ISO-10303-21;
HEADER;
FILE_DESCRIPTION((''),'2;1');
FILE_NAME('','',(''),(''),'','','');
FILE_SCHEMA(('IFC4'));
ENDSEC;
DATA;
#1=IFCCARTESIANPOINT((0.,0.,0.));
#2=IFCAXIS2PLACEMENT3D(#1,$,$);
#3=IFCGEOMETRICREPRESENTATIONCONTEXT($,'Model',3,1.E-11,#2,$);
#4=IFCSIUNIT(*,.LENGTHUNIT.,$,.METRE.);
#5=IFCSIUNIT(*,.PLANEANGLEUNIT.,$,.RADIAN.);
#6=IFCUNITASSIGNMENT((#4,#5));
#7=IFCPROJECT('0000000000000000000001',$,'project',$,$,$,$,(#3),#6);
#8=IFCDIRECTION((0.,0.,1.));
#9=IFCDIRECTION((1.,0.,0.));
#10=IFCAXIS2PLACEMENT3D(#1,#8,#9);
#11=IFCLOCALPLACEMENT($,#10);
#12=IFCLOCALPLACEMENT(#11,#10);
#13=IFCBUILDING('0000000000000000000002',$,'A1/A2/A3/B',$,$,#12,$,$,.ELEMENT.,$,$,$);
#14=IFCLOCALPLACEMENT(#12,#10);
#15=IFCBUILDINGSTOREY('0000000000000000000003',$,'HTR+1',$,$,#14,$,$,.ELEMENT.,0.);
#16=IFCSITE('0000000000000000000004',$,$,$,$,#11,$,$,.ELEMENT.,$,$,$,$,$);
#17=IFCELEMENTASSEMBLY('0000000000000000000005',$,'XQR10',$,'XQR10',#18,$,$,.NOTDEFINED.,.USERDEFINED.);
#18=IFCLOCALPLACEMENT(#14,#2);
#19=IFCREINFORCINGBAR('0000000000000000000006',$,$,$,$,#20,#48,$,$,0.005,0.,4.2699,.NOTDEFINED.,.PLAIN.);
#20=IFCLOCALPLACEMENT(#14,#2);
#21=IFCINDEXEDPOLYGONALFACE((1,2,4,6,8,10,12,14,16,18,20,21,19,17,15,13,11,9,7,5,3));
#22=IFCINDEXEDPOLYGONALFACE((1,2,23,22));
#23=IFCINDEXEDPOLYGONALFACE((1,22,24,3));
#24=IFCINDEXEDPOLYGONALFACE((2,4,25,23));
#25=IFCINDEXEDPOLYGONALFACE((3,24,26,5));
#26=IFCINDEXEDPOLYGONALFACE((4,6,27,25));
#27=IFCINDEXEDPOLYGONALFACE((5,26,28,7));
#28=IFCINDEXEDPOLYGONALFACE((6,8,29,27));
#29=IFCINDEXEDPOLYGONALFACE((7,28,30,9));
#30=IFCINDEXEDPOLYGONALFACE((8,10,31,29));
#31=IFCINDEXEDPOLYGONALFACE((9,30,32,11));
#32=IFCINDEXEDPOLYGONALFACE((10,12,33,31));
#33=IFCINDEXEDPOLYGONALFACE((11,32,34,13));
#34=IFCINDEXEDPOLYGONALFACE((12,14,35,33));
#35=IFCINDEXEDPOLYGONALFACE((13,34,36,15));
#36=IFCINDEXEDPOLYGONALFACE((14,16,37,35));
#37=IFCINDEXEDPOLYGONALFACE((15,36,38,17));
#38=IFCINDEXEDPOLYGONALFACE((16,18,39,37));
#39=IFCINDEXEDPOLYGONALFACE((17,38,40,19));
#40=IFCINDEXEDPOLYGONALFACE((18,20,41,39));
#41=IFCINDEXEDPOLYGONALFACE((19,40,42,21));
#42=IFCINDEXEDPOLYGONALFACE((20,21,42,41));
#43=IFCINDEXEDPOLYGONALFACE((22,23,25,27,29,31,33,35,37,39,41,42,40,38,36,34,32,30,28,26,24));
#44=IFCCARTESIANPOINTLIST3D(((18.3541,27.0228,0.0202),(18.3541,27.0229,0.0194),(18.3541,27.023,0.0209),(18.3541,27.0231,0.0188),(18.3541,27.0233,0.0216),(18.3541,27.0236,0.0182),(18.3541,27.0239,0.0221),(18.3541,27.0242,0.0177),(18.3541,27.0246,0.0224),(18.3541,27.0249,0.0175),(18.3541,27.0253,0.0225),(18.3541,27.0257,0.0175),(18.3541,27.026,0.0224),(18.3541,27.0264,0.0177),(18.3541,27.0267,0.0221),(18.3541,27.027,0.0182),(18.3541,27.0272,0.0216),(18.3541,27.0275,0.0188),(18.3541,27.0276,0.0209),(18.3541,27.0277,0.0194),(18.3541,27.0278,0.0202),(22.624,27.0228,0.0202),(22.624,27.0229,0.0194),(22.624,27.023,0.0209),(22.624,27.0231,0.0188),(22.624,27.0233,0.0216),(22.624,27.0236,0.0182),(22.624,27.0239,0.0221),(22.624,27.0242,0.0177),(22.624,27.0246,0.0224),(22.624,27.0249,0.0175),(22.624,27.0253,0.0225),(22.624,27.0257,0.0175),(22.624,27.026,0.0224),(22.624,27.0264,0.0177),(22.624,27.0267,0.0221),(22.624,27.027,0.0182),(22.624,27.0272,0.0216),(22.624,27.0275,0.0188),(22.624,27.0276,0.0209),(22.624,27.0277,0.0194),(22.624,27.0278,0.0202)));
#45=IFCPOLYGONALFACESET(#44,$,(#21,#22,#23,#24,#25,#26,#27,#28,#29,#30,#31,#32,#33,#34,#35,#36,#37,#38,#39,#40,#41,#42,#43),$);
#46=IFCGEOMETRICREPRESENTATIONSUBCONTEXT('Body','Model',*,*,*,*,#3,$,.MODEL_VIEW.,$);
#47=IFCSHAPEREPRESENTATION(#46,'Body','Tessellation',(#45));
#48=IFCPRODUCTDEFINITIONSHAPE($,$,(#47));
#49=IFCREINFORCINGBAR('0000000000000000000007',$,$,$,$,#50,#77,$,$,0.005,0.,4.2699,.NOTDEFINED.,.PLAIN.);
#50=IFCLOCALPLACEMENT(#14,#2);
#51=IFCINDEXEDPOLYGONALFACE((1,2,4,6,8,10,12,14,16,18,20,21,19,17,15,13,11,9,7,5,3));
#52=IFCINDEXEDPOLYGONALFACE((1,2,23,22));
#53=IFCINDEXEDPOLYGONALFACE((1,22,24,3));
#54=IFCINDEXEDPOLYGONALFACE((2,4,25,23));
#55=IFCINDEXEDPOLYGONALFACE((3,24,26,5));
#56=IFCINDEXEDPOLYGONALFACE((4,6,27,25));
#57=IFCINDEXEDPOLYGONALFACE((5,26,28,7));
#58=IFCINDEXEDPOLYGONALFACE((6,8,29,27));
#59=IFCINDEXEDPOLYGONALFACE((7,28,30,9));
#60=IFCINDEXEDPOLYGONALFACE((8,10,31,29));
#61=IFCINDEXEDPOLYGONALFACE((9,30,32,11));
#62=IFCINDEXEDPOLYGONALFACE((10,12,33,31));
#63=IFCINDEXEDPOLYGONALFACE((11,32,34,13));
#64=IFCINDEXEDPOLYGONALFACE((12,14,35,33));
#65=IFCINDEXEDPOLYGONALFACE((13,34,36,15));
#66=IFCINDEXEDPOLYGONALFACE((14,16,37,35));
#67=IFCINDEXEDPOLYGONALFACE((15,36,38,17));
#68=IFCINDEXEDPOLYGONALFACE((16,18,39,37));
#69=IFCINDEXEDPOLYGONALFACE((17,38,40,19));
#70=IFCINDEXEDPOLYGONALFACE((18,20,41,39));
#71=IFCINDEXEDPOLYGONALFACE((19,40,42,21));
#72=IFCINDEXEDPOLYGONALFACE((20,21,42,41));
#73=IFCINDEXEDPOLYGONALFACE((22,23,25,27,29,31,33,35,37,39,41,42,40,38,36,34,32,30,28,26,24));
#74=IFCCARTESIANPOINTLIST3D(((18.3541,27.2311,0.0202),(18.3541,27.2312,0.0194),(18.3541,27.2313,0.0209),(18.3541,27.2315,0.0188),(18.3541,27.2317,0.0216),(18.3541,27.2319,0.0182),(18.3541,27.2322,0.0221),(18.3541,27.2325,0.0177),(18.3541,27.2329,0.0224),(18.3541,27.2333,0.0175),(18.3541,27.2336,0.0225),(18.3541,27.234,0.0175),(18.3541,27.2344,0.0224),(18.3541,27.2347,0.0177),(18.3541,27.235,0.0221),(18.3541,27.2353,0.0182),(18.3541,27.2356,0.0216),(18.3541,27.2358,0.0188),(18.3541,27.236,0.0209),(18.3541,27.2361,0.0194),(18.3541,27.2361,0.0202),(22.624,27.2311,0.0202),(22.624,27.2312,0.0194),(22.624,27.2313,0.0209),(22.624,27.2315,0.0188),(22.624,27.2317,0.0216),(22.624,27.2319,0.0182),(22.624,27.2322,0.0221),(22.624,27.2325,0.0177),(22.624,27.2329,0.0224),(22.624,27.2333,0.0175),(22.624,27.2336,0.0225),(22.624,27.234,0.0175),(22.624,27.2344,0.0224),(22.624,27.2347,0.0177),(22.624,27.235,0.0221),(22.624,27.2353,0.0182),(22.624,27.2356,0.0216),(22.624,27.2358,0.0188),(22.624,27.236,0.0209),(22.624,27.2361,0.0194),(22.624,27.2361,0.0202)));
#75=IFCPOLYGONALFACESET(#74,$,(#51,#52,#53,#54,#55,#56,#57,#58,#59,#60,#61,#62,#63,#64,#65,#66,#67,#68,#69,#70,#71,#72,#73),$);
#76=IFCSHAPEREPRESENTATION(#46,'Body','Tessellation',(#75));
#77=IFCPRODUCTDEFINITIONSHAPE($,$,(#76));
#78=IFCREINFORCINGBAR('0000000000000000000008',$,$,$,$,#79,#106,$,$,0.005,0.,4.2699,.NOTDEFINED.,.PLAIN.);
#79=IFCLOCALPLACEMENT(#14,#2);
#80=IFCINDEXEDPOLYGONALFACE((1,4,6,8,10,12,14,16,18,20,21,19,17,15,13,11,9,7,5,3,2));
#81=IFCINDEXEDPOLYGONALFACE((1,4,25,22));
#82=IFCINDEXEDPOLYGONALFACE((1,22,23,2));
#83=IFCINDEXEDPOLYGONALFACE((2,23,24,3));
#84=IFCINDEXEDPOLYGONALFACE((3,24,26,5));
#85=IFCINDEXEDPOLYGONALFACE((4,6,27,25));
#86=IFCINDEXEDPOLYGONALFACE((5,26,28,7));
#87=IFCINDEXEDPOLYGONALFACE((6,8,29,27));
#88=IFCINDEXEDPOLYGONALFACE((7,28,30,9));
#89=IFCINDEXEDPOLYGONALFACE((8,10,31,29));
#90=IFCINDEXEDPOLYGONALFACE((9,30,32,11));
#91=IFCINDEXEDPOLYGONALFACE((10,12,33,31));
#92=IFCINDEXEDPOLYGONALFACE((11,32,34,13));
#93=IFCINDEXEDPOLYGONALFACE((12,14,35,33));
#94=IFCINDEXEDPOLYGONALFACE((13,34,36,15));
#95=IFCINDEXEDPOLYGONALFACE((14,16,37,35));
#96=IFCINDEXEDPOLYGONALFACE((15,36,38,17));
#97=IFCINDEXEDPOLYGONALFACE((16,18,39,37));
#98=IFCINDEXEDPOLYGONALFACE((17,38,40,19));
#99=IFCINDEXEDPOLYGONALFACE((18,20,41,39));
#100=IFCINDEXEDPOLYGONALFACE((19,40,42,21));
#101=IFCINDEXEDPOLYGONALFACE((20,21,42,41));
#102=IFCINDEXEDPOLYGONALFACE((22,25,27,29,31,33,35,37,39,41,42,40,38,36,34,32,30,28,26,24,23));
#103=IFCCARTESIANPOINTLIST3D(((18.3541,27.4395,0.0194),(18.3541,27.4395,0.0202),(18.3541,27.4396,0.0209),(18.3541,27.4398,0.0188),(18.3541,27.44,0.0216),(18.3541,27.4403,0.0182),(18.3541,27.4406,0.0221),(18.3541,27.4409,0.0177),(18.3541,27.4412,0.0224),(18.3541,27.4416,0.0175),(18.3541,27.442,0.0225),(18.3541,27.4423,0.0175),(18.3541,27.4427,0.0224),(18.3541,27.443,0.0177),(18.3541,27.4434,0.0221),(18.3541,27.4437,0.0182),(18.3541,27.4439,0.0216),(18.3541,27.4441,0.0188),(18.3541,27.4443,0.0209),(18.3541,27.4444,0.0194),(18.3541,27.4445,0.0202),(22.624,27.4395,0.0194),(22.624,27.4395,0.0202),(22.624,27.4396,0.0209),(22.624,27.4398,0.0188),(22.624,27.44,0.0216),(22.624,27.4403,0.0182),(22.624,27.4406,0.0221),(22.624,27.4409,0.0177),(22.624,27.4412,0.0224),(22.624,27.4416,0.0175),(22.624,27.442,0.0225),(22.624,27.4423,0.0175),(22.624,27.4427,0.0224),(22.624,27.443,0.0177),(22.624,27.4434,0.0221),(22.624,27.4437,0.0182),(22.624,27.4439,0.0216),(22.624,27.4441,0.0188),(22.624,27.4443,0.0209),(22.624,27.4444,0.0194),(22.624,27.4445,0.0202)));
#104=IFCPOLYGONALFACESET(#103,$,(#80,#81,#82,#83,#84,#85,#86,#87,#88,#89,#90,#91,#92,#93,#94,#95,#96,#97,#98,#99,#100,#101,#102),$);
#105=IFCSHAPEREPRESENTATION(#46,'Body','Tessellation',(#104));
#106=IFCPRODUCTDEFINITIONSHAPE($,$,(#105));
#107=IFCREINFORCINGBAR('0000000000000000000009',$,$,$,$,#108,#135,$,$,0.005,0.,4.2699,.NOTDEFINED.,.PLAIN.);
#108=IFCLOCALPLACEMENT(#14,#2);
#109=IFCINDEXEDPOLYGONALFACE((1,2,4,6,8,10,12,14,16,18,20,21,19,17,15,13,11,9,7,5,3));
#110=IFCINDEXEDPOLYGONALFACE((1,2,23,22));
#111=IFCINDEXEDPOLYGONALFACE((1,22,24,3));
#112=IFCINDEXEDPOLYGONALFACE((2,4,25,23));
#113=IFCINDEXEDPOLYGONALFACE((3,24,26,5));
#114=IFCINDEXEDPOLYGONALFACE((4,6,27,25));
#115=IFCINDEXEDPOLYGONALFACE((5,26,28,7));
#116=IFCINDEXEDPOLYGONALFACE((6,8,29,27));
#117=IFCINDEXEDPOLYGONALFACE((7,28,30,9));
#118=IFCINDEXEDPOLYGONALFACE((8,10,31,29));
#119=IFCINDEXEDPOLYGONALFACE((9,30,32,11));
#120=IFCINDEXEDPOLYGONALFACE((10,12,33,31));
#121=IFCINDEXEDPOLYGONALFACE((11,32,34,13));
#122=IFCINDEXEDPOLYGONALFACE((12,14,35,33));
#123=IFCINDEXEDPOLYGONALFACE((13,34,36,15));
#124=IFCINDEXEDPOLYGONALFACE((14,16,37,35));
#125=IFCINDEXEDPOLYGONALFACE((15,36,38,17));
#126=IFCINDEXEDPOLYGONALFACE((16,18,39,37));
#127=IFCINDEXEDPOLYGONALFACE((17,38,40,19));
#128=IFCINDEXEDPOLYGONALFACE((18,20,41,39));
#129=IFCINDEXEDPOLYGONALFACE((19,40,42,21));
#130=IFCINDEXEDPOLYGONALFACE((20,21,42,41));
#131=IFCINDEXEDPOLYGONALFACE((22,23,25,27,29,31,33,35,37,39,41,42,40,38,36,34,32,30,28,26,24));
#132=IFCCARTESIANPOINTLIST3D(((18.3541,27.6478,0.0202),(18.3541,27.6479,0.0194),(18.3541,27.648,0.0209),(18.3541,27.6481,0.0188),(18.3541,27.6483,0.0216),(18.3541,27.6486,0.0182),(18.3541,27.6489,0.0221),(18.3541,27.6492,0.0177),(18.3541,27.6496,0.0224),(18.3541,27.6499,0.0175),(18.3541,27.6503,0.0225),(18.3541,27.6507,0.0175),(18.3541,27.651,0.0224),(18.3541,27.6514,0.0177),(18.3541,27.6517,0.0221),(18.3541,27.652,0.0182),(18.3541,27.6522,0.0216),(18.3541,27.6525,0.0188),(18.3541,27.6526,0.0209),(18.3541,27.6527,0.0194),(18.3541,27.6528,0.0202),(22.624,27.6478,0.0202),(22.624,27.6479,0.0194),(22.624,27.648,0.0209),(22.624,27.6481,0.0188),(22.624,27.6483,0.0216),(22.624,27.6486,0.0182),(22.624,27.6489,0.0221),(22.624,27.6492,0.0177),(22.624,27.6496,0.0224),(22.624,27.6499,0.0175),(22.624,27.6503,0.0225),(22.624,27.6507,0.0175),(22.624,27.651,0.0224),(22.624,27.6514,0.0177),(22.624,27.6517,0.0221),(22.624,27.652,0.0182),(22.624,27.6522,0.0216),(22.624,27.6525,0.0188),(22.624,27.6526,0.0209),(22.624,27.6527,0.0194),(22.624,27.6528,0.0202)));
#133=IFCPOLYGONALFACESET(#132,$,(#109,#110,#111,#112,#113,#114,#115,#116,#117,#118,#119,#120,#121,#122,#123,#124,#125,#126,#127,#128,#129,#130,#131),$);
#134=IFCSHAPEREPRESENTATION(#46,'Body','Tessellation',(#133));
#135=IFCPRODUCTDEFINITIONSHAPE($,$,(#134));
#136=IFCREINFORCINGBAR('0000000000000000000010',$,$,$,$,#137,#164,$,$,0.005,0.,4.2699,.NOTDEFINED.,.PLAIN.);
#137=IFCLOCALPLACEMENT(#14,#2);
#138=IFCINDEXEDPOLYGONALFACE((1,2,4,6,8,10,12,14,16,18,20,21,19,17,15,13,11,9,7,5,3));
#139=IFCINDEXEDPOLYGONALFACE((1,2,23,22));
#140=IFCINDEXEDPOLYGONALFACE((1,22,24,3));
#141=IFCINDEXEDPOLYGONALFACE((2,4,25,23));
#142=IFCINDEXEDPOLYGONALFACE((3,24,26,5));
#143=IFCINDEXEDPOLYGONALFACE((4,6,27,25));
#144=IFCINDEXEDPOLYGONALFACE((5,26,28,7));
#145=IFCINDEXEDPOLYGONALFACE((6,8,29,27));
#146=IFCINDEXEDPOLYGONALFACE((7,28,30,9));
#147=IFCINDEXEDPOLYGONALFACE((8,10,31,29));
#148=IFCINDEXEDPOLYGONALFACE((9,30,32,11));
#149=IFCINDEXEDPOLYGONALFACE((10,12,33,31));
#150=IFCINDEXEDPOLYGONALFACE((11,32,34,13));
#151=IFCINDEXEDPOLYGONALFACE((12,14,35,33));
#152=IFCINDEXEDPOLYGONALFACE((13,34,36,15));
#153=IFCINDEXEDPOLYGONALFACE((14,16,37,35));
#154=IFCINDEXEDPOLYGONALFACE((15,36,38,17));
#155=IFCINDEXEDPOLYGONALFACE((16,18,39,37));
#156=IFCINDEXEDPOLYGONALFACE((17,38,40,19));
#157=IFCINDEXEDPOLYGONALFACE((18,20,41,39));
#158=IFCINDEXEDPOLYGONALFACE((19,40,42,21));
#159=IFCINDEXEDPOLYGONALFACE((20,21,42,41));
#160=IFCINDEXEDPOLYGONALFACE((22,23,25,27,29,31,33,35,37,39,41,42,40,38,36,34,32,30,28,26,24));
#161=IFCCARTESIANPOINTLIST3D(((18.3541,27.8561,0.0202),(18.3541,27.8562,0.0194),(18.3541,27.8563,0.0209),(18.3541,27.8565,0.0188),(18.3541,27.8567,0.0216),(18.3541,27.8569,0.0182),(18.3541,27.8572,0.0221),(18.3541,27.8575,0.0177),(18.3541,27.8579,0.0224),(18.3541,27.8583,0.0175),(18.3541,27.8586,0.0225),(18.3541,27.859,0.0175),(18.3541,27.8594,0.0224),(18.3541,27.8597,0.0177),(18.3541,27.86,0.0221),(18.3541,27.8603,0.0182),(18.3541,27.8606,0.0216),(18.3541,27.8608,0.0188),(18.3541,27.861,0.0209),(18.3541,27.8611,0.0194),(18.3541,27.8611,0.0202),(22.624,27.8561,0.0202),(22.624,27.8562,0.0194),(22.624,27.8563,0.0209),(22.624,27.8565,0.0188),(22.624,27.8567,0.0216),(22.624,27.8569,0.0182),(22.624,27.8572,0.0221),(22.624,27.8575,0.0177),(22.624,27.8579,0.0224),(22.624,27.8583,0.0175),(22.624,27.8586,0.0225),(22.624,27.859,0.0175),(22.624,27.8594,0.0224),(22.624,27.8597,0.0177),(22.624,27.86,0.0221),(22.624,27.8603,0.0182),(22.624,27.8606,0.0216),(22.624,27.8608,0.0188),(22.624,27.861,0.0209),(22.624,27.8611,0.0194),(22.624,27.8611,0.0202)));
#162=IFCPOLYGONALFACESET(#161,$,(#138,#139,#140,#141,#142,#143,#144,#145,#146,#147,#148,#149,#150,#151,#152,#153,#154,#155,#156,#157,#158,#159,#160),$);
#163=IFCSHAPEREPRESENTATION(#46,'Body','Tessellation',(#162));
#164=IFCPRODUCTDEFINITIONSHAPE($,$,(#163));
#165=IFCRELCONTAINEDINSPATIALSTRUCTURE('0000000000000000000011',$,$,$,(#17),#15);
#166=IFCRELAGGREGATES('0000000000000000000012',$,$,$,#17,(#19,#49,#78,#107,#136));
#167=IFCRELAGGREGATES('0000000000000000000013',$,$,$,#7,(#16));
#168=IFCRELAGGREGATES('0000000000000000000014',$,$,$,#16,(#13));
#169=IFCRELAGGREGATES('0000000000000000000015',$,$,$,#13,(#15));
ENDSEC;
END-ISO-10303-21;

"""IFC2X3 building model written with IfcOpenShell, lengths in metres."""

from ifc_helpers import new_model, entity, si_unit, origin, origin_with_axes, place, context, subcontext, project, spatial, shape, element, aggregate, save


model = new_model("IFC2X3")

# Units and contexts
model_context = context("Model", 3, precision=1e-11, world=origin())
body_context = subcontext(model_context, "Body", "Model", "MODEL_VIEW")
ifc_project = project(units=[si_unit("LENGTHUNIT", "METRE"), si_unit("PLANEANGLEUNIT", "RADIAN")], contexts=[model_context])

# Site, building, storey
site_placement = place(None, origin_with_axes())
site = spatial("IfcSite", under=ifc_project, at=site_placement, CompositionType="ELEMENT")
building_placement = place(site_placement, origin_with_axes())
building = spatial("IfcBuilding", under=site, at=building_placement, Name="A1/A2/A3/B", CompositionType="ELEMENT")
storey_placement = place(building_placement, origin_with_axes())
storey = spatial("IfcBuildingStorey", under=building, at=storey_placement, Name="HTR+1", CompositionType="ELEMENT", Elevation=0.0)

# Element assembly, reinforcing bars
assembly_1_placement = place(storey_placement, origin_with_axes())
assembly_1 = element("IfcElementAssembly", 1, at=assembly_1_placement, inside=storey, Name="XQR10", ObjectType="XQR10", AssemblyPlace="NOTDEFINED", PredefinedType="USERDEFINED")
reinforcing_bar_1_placement = place(assembly_1_placement, origin_with_axes())
reinforcing_bar_1 = element("IfcReinforcingBar", 2, at=reinforcing_bar_1_placement, BarLength=4.2699, BarRole="NOTDEFINED", BarSurface="PLAIN", CrossSectionArea=0.0, NominalDiameter=0.005, shapes=[
    shape(body_context, "Body", "AdvancedSweptSolid", [entity("IfcSweptDiskSolid", entity("IfcPolyline", [entity("IfcCartesianPoint", [18.3541, 27.0253, 0.02]), entity("IfcCartesianPoint", [22.624, 27.0253, 0.02])]), 0.0025, None, 0.0, 4.2699)]),
    shape(body_context, "Body", "AdvancedSweptSolid", [entity("IfcSweptDiskSolid", entity("IfcPolyline", [entity("IfcCartesianPoint", [18.3541, 27.0253, 0.02]), entity("IfcCartesianPoint", [22.624, 27.0253, 0.02])]), 0.0025, None, 0.0, 4.2699)]),
])
reinforcing_bar_2_placement = place(assembly_1_placement, origin_with_axes())
reinforcing_bar_2 = element("IfcReinforcingBar", 3, at=reinforcing_bar_2_placement, BarLength=4.2699, BarRole="NOTDEFINED", BarSurface="PLAIN", CrossSectionArea=0.0, NominalDiameter=0.005, shapes=[
    shape(body_context, "Body", "AdvancedSweptSolid", [entity("IfcSweptDiskSolid", entity("IfcPolyline", [entity("IfcCartesianPoint", [18.3541, 27.2336, 0.02]), entity("IfcCartesianPoint", [22.624, 27.2336, 0.02])]), 0.0025, None, 0.0, 4.2699)]),
    shape(body_context, "Body", "AdvancedSweptSolid", [entity("IfcSweptDiskSolid", entity("IfcPolyline", [entity("IfcCartesianPoint", [18.3541, 27.2336, 0.02]), entity("IfcCartesianPoint", [22.624, 27.2336, 0.02])]), 0.0025, None, 0.0, 4.2699)]),
])
reinforcing_bar_3_placement = place(assembly_1_placement, origin_with_axes())
reinforcing_bar_3 = element("IfcReinforcingBar", 4, at=reinforcing_bar_3_placement, BarLength=4.2699, BarRole="NOTDEFINED", BarSurface="PLAIN", CrossSectionArea=0.0, NominalDiameter=0.005, shapes=[
    shape(body_context, "Body", "AdvancedSweptSolid", [entity("IfcSweptDiskSolid", entity("IfcPolyline", [entity("IfcCartesianPoint", [18.3541, 27.442, 0.02]), entity("IfcCartesianPoint", [22.624, 27.442, 0.02])]), 0.0025, None, 0.0, 4.2699)]),
    shape(body_context, "Body", "AdvancedSweptSolid", [entity("IfcSweptDiskSolid", entity("IfcPolyline", [entity("IfcCartesianPoint", [18.3541, 27.442, 0.02]), entity("IfcCartesianPoint", [22.624, 27.442, 0.02])]), 0.0025, None, 0.0, 4.2699)]),
])
reinforcing_bar_4_placement = place(assembly_1_placement, origin_with_axes())
reinforcing_bar_4 = element("IfcReinforcingBar", 5, at=reinforcing_bar_4_placement, BarLength=4.2699, BarRole="NOTDEFINED", BarSurface="PLAIN", CrossSectionArea=0.0, NominalDiameter=0.005, shapes=[
    shape(body_context, "Body", "AdvancedSweptSolid", [entity("IfcSweptDiskSolid", entity("IfcPolyline", [entity("IfcCartesianPoint", [18.3541, 27.6503, 0.02]), entity("IfcCartesianPoint", [22.624, 27.6503, 0.02])]), 0.0025, None, 0.0, 4.2699)]),
    shape(body_context, "Body", "AdvancedSweptSolid", [entity("IfcSweptDiskSolid", entity("IfcPolyline", [entity("IfcCartesianPoint", [18.3541, 27.6503, 0.02]), entity("IfcCartesianPoint", [22.624, 27.6503, 0.02])]), 0.0025, None, 0.0, 4.2699)]),
])
reinforcing_bar_5_placement = place(assembly_1_placement, origin_with_axes())
reinforcing_bar_5 = element("IfcReinforcingBar", 6, at=reinforcing_bar_5_placement, BarLength=4.2699, BarRole="NOTDEFINED", BarSurface="PLAIN", CrossSectionArea=0.0, NominalDiameter=0.005, shapes=[
    shape(body_context, "Body", "AdvancedSweptSolid", [entity("IfcSweptDiskSolid", entity("IfcPolyline", [entity("IfcCartesianPoint", [18.3541, 27.8586, 0.02]), entity("IfcCartesianPoint", [22.624, 27.8586, 0.02])]), 0.0025, None, 0.0, 4.2699)]),
    shape(body_context, "Body", "AdvancedSweptSolid", [entity("IfcSweptDiskSolid", entity("IfcPolyline", [entity("IfcCartesianPoint", [18.3541, 27.8586, 0.02]), entity("IfcCartesianPoint", [22.624, 27.8586, 0.02])]), 0.0025, None, 0.0, 4.2699)]),
])
aggregate(assembly_1, [reinforcing_bar_1, reinforcing_bar_2, reinforcing_bar_3, reinforcing_bar_4, reinforcing_bar_5])

save(model, "model.ifc")
